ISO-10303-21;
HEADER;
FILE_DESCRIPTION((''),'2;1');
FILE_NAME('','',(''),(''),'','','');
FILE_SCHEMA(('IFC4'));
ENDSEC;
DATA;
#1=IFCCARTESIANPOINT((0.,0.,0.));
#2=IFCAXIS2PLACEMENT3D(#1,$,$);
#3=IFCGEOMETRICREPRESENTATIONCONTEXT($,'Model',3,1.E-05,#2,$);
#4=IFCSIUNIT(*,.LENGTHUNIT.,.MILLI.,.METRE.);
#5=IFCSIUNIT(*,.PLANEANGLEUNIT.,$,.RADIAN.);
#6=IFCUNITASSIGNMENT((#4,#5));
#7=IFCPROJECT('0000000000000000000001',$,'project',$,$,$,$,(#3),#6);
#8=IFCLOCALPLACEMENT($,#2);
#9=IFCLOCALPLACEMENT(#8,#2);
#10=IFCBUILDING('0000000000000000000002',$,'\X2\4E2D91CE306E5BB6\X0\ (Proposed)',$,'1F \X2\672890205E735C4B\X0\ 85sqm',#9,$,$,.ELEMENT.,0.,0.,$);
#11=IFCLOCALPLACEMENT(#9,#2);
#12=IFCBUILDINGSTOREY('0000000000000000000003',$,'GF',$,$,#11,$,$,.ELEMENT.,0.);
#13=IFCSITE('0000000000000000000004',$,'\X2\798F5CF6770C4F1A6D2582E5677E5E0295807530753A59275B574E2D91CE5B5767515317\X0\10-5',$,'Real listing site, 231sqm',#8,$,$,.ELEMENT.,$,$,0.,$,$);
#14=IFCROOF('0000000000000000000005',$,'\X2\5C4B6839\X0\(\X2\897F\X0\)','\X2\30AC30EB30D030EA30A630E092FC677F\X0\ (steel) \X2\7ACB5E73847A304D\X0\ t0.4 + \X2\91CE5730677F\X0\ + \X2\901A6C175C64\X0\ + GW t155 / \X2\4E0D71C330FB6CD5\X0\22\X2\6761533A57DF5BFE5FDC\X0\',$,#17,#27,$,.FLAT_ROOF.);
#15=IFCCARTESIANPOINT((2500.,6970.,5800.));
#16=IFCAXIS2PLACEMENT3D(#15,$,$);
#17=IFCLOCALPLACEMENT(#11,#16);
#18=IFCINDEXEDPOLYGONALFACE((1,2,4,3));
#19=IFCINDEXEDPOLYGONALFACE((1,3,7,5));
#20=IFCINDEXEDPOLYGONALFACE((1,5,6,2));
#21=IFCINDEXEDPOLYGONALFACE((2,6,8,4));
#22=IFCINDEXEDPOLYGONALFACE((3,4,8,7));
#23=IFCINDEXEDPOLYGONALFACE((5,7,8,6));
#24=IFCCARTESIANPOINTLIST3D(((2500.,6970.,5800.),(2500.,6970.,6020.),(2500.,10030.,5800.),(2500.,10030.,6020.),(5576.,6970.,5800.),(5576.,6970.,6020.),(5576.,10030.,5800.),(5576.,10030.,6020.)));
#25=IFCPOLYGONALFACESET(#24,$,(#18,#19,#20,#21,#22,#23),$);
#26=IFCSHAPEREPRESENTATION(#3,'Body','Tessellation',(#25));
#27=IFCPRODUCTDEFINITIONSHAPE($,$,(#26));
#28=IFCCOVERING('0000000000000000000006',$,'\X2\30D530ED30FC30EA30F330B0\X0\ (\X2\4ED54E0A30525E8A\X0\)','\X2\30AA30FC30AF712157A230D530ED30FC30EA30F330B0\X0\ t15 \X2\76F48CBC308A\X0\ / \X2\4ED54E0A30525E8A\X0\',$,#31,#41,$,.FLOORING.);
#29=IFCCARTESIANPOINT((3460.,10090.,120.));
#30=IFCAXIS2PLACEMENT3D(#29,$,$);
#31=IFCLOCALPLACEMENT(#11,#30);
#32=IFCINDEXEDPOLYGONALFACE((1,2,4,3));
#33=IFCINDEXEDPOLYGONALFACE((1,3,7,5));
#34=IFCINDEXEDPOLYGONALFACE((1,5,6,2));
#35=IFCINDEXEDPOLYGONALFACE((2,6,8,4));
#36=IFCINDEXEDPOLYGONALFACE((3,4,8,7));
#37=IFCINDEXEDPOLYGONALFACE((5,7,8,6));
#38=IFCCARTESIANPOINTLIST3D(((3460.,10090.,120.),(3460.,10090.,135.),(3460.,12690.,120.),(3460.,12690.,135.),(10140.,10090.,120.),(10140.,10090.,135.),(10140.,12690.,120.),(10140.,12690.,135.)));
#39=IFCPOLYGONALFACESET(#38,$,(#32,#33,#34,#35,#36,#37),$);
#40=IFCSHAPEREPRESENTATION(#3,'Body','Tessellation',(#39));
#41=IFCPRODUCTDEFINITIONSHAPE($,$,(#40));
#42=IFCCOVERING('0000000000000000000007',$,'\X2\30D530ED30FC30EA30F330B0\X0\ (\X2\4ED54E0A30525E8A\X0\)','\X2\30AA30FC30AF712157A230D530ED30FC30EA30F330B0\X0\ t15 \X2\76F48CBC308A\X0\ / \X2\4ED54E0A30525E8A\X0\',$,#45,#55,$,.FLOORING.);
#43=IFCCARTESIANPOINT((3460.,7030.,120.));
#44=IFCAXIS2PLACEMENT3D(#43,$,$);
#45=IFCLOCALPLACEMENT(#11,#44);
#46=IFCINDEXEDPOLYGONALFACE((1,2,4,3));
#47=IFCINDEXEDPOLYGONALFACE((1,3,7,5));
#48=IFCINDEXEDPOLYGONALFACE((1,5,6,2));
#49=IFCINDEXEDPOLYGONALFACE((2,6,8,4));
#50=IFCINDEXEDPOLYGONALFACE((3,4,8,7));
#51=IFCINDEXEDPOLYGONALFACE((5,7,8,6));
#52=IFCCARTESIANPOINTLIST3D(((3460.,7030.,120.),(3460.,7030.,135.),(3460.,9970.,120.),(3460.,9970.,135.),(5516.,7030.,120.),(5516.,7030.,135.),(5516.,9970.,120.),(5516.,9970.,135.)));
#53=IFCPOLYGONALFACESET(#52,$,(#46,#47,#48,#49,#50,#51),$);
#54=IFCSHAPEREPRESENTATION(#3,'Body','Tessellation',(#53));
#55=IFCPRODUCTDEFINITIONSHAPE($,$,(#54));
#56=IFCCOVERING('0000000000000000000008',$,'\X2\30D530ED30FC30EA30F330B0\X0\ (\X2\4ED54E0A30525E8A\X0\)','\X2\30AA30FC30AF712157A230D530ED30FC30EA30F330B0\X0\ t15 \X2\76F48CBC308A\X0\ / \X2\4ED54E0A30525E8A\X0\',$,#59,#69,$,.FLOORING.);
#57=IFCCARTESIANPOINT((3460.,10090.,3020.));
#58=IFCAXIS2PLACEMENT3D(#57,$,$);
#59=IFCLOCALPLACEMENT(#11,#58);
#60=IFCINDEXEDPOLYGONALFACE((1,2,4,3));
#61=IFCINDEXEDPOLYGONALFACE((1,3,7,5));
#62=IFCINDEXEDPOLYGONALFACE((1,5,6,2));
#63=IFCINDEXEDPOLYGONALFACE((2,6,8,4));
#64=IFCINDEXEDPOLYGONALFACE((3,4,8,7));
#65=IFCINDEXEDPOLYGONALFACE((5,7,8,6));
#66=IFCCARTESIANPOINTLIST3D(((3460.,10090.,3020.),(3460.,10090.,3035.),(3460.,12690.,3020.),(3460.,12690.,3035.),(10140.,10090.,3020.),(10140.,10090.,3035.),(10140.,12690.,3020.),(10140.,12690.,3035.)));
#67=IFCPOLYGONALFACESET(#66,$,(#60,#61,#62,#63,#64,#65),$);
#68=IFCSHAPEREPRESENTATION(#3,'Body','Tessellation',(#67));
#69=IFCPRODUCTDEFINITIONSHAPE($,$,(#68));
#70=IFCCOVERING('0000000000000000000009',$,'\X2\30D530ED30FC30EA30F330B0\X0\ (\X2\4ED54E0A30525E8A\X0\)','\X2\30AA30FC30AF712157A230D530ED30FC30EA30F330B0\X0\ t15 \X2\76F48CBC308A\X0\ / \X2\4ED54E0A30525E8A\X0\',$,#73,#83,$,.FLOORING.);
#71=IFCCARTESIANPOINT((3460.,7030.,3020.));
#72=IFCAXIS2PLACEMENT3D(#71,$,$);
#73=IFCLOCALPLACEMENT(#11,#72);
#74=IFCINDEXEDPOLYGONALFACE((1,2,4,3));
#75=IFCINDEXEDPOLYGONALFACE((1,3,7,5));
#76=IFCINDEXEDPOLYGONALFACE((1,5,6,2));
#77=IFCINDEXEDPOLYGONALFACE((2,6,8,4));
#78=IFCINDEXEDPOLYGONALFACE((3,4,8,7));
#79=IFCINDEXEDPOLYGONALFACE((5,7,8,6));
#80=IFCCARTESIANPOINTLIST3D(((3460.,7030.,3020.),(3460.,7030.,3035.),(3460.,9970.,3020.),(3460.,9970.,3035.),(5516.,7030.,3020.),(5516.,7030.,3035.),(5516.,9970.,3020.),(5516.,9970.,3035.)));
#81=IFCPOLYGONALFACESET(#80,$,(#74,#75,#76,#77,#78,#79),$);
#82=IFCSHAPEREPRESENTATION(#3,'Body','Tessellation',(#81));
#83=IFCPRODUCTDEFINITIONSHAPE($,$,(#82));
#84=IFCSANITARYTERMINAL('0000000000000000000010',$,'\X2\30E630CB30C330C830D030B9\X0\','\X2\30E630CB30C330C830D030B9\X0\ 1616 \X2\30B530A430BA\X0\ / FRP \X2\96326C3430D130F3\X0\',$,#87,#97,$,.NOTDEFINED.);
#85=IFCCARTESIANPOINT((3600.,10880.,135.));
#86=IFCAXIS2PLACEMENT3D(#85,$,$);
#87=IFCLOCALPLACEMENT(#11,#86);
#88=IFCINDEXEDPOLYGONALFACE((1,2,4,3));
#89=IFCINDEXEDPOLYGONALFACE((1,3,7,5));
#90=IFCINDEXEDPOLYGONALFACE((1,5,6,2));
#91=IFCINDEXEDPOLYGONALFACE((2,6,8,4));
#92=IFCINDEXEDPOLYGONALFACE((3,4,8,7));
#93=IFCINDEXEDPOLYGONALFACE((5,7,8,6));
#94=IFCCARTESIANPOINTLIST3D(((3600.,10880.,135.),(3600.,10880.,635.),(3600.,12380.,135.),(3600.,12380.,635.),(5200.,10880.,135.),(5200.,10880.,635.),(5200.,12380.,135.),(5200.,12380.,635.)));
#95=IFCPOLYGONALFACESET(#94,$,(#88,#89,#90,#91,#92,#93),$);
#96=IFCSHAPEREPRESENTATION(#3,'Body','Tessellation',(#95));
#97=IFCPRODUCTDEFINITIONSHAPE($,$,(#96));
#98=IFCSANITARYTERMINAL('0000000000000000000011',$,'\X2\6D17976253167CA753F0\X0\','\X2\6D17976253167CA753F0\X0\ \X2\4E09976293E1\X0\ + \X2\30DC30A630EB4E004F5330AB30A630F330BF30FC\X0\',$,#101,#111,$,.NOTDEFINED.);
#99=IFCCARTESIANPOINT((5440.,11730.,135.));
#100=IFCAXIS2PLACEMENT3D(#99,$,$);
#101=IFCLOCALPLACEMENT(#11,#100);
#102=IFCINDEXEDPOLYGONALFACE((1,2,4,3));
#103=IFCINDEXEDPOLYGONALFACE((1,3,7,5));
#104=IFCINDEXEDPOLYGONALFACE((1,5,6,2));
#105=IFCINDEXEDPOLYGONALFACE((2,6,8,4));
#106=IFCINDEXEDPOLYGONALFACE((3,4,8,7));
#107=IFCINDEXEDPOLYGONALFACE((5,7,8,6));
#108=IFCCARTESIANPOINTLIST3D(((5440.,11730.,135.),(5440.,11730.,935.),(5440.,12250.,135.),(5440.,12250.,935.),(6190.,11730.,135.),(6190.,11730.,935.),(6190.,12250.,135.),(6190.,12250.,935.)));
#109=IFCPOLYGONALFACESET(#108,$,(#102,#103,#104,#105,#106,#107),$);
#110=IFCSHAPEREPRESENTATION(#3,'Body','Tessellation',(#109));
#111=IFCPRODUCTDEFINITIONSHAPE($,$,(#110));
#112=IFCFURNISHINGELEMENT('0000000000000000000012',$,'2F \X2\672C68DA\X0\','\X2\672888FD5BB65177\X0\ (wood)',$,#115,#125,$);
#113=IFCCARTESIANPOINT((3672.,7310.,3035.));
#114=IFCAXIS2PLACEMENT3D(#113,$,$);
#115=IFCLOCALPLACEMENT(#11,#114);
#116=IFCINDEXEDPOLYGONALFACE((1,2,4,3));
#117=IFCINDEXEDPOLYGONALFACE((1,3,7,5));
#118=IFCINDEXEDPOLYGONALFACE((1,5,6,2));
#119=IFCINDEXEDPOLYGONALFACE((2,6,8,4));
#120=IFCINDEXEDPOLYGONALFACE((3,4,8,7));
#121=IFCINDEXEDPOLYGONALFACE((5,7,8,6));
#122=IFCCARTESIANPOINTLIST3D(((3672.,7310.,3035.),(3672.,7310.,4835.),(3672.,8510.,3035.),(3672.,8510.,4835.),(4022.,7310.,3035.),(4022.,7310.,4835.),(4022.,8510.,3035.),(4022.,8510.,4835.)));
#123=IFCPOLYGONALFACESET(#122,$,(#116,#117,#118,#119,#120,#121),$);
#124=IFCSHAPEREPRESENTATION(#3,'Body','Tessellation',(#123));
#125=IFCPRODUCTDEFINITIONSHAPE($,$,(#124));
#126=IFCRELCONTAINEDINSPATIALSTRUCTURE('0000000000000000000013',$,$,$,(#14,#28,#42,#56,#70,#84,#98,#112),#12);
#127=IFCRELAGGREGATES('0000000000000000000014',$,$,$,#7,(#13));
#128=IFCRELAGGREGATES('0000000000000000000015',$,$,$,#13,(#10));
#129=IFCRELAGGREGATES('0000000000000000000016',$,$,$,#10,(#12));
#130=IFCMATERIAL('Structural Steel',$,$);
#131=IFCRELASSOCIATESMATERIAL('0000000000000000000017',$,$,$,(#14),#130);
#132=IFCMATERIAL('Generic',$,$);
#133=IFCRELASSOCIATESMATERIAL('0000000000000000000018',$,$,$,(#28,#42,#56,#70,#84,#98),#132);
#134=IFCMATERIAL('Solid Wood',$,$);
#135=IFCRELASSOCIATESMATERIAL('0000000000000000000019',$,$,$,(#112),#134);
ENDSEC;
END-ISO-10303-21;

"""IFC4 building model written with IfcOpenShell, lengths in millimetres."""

from ifc_helpers import new_model, si_unit, frame, frame_2d, origin, place, context, project, spatial, rectangle, extrude, material, element, save


model = new_model("IFC4")

# Units and contexts
model_context = context("Model", 3, precision=1e-05, world=origin())
ifc_project = project(units=[si_unit("LENGTHUNIT", "METRE", prefix="MILLI"), si_unit("PLANEANGLEUNIT", "RADIAN")], contexts=[model_context])

# Site, building, storey
site_placement = place(None, origin())
site = spatial("IfcSite", under=ifc_project, at=site_placement, Name="福島県会津若松市門田町大字中野字村北10-5", ObjectType="Real listing site, 231sqm", CompositionType="ELEMENT", RefElevation=0.0)
building_placement = place(site_placement, origin())
building = spatial("IfcBuilding", under=site, at=building_placement, Name="中野の家 (Proposed)", ObjectType="1F 木造平屋 85sqm", CompositionType="ELEMENT", ElevationOfRefHeight=0.0, ElevationOfTerrain=0.0)
storey_placement = place(building_placement, origin())
storey = spatial("IfcBuildingStorey", under=building, at=storey_placement, Name="GF", CompositionType="ELEMENT", Elevation=0.0)

# Shared definitions
ifc_material_1 = material(Name="Solid Wood")

# Roof
ifc_material_2 = material(Name="Structural Steel")
roof_placement = place(storey_placement, frame((2500.0, 6970.0, 5800.0)))
element("IfcRoof", 1, at=roof_placement, inside=storey, material=ifc_material_2, Name="屋根(西)", Description="ガルバリウム鋼板 (steel) 立平葺き t0.4 + 野地板 + 通気層 + GW t155 / 不燃・法22条区域対応", PredefinedType="FLAT_ROOF", context=model_context, shape_type="SweptSolid", body=[
    extrude(rectangle(XDim=3076.0, YDim=3060.0, at=frame_2d((1538.0, 1530.0))), frame((2500.0, 6970.0, 5800.0)), (0.0, 0.0, 1.0), 220.0),
])

# Coverings
ifc_material_3 = material(Name="Generic")
covering_1_placement = place(storey_placement, frame((3460.0, 10090.0, 120.0)))
element("IfcCovering", 2, at=covering_1_placement, inside=storey, material=ifc_material_3, Name="フローリング (仕上げ床)", Description="オーク無垢フローリング t15 直貼り / 仕上げ床", PredefinedType="FLOORING", context=model_context, shape_type="SweptSolid", body=[
    extrude(rectangle(XDim=6680.0, YDim=2600.0, at=frame_2d((3340.0, 1300.0))), frame((3460.0, 10090.0, 120.0)), (0.0, 0.0, 1.0), 15.0),
])
covering_2_placement = place(storey_placement, frame((3460.0, 7030.0, 120.0)))
element("IfcCovering", 3, at=covering_2_placement, inside=storey, material=ifc_material_3, Name="フローリング (仕上げ床)", Description="オーク無垢フローリング t15 直貼り / 仕上げ床", PredefinedType="FLOORING", context=model_context, shape_type="SweptSolid", body=[
    extrude(rectangle(XDim=2056.0, YDim=2940.0, at=frame_2d((1028.0, 1470.0))), frame((3460.0, 7030.0, 120.0)), (0.0, 0.0, 1.0), 15.0),
])
covering_3_placement = place(storey_placement, frame((3460.0, 10090.0, 3020.0)))
element("IfcCovering", 4, at=covering_3_placement, inside=storey, material=ifc_material_3, Name="フローリング (仕上げ床)", Description="オーク無垢フローリング t15 直貼り / 仕上げ床", PredefinedType="FLOORING", context=model_context, shape_type="SweptSolid", body=[
    extrude(rectangle(XDim=6680.0, YDim=2600.0, at=frame_2d((3340.0, 1300.0))), frame((3460.0, 10090.0, 3020.0)), (0.0, 0.0, 1.0), 15.0),
])
covering_4_placement = place(storey_placement, frame((3460.0, 7030.0, 3020.0)))
element("IfcCovering", 5, at=covering_4_placement, inside=storey, material=ifc_material_3, Name="フローリング (仕上げ床)", Description="オーク無垢フローリング t15 直貼り / 仕上げ床", PredefinedType="FLOORING", context=model_context, shape_type="SweptSolid", body=[
    extrude(rectangle(XDim=2056.0, YDim=2940.0, at=frame_2d((1028.0, 1470.0))), frame((3460.0, 7030.0, 3020.0)), (0.0, 0.0, 1.0), 15.0),
])

# Sanitary terminals
sanitary_terminal_1_placement = place(storey_placement, frame((3600.0, 10880.0, 135.0)))
element("IfcSanitaryTerminal", 6, at=sanitary_terminal_1_placement, inside=storey, material=ifc_material_3, Name="ユニットバス", Description="ユニットバス 1616 サイズ / FRP 防水パン", PredefinedType="NOTDEFINED", context=model_context, shape_type="SweptSolid", body=[
    extrude(rectangle(XDim=1600.0, YDim=1500.0, at=frame_2d((800.0, 750.0))), frame((3600.0, 10880.0, 135.0)), (0.0, 0.0, 1.0), 500.0),
])
sanitary_terminal_2_placement = place(storey_placement, frame((5440.0, 11730.0, 135.0)))
element("IfcSanitaryTerminal", 7, at=sanitary_terminal_2_placement, inside=storey, material=ifc_material_3, Name="洗面化粧台", Description="洗面化粧台 三面鏡 + ボウル一体カウンター", PredefinedType="NOTDEFINED", context=model_context, shape_type="SweptSolid", body=[
    extrude(rectangle(XDim=750.0, YDim=520.0, at=frame_2d((375.0, 260.0))), frame((5440.0, 11730.0, 135.0)), (0.0, 0.0, 1.0), 800.0),
])

# Furnishing element
furnishing_placement = place(storey_placement, frame((3672.0, 7310.0, 3035.0)))
element("IfcFurnishingElement", 8, at=furnishing_placement, inside=storey, material=ifc_material_1, Name="2F 本棚", Description="木製家具 (wood)", context=model_context, shape_type="SweptSolid", body=[
    extrude(rectangle(XDim=350.0, YDim=1200.0, at=frame_2d((175.0, 600.0))), frame((3672.0, 7310.0, 3035.0)), (0.0, 0.0, 1.0), 1800.0),
])

save(model, "model.ifc")
